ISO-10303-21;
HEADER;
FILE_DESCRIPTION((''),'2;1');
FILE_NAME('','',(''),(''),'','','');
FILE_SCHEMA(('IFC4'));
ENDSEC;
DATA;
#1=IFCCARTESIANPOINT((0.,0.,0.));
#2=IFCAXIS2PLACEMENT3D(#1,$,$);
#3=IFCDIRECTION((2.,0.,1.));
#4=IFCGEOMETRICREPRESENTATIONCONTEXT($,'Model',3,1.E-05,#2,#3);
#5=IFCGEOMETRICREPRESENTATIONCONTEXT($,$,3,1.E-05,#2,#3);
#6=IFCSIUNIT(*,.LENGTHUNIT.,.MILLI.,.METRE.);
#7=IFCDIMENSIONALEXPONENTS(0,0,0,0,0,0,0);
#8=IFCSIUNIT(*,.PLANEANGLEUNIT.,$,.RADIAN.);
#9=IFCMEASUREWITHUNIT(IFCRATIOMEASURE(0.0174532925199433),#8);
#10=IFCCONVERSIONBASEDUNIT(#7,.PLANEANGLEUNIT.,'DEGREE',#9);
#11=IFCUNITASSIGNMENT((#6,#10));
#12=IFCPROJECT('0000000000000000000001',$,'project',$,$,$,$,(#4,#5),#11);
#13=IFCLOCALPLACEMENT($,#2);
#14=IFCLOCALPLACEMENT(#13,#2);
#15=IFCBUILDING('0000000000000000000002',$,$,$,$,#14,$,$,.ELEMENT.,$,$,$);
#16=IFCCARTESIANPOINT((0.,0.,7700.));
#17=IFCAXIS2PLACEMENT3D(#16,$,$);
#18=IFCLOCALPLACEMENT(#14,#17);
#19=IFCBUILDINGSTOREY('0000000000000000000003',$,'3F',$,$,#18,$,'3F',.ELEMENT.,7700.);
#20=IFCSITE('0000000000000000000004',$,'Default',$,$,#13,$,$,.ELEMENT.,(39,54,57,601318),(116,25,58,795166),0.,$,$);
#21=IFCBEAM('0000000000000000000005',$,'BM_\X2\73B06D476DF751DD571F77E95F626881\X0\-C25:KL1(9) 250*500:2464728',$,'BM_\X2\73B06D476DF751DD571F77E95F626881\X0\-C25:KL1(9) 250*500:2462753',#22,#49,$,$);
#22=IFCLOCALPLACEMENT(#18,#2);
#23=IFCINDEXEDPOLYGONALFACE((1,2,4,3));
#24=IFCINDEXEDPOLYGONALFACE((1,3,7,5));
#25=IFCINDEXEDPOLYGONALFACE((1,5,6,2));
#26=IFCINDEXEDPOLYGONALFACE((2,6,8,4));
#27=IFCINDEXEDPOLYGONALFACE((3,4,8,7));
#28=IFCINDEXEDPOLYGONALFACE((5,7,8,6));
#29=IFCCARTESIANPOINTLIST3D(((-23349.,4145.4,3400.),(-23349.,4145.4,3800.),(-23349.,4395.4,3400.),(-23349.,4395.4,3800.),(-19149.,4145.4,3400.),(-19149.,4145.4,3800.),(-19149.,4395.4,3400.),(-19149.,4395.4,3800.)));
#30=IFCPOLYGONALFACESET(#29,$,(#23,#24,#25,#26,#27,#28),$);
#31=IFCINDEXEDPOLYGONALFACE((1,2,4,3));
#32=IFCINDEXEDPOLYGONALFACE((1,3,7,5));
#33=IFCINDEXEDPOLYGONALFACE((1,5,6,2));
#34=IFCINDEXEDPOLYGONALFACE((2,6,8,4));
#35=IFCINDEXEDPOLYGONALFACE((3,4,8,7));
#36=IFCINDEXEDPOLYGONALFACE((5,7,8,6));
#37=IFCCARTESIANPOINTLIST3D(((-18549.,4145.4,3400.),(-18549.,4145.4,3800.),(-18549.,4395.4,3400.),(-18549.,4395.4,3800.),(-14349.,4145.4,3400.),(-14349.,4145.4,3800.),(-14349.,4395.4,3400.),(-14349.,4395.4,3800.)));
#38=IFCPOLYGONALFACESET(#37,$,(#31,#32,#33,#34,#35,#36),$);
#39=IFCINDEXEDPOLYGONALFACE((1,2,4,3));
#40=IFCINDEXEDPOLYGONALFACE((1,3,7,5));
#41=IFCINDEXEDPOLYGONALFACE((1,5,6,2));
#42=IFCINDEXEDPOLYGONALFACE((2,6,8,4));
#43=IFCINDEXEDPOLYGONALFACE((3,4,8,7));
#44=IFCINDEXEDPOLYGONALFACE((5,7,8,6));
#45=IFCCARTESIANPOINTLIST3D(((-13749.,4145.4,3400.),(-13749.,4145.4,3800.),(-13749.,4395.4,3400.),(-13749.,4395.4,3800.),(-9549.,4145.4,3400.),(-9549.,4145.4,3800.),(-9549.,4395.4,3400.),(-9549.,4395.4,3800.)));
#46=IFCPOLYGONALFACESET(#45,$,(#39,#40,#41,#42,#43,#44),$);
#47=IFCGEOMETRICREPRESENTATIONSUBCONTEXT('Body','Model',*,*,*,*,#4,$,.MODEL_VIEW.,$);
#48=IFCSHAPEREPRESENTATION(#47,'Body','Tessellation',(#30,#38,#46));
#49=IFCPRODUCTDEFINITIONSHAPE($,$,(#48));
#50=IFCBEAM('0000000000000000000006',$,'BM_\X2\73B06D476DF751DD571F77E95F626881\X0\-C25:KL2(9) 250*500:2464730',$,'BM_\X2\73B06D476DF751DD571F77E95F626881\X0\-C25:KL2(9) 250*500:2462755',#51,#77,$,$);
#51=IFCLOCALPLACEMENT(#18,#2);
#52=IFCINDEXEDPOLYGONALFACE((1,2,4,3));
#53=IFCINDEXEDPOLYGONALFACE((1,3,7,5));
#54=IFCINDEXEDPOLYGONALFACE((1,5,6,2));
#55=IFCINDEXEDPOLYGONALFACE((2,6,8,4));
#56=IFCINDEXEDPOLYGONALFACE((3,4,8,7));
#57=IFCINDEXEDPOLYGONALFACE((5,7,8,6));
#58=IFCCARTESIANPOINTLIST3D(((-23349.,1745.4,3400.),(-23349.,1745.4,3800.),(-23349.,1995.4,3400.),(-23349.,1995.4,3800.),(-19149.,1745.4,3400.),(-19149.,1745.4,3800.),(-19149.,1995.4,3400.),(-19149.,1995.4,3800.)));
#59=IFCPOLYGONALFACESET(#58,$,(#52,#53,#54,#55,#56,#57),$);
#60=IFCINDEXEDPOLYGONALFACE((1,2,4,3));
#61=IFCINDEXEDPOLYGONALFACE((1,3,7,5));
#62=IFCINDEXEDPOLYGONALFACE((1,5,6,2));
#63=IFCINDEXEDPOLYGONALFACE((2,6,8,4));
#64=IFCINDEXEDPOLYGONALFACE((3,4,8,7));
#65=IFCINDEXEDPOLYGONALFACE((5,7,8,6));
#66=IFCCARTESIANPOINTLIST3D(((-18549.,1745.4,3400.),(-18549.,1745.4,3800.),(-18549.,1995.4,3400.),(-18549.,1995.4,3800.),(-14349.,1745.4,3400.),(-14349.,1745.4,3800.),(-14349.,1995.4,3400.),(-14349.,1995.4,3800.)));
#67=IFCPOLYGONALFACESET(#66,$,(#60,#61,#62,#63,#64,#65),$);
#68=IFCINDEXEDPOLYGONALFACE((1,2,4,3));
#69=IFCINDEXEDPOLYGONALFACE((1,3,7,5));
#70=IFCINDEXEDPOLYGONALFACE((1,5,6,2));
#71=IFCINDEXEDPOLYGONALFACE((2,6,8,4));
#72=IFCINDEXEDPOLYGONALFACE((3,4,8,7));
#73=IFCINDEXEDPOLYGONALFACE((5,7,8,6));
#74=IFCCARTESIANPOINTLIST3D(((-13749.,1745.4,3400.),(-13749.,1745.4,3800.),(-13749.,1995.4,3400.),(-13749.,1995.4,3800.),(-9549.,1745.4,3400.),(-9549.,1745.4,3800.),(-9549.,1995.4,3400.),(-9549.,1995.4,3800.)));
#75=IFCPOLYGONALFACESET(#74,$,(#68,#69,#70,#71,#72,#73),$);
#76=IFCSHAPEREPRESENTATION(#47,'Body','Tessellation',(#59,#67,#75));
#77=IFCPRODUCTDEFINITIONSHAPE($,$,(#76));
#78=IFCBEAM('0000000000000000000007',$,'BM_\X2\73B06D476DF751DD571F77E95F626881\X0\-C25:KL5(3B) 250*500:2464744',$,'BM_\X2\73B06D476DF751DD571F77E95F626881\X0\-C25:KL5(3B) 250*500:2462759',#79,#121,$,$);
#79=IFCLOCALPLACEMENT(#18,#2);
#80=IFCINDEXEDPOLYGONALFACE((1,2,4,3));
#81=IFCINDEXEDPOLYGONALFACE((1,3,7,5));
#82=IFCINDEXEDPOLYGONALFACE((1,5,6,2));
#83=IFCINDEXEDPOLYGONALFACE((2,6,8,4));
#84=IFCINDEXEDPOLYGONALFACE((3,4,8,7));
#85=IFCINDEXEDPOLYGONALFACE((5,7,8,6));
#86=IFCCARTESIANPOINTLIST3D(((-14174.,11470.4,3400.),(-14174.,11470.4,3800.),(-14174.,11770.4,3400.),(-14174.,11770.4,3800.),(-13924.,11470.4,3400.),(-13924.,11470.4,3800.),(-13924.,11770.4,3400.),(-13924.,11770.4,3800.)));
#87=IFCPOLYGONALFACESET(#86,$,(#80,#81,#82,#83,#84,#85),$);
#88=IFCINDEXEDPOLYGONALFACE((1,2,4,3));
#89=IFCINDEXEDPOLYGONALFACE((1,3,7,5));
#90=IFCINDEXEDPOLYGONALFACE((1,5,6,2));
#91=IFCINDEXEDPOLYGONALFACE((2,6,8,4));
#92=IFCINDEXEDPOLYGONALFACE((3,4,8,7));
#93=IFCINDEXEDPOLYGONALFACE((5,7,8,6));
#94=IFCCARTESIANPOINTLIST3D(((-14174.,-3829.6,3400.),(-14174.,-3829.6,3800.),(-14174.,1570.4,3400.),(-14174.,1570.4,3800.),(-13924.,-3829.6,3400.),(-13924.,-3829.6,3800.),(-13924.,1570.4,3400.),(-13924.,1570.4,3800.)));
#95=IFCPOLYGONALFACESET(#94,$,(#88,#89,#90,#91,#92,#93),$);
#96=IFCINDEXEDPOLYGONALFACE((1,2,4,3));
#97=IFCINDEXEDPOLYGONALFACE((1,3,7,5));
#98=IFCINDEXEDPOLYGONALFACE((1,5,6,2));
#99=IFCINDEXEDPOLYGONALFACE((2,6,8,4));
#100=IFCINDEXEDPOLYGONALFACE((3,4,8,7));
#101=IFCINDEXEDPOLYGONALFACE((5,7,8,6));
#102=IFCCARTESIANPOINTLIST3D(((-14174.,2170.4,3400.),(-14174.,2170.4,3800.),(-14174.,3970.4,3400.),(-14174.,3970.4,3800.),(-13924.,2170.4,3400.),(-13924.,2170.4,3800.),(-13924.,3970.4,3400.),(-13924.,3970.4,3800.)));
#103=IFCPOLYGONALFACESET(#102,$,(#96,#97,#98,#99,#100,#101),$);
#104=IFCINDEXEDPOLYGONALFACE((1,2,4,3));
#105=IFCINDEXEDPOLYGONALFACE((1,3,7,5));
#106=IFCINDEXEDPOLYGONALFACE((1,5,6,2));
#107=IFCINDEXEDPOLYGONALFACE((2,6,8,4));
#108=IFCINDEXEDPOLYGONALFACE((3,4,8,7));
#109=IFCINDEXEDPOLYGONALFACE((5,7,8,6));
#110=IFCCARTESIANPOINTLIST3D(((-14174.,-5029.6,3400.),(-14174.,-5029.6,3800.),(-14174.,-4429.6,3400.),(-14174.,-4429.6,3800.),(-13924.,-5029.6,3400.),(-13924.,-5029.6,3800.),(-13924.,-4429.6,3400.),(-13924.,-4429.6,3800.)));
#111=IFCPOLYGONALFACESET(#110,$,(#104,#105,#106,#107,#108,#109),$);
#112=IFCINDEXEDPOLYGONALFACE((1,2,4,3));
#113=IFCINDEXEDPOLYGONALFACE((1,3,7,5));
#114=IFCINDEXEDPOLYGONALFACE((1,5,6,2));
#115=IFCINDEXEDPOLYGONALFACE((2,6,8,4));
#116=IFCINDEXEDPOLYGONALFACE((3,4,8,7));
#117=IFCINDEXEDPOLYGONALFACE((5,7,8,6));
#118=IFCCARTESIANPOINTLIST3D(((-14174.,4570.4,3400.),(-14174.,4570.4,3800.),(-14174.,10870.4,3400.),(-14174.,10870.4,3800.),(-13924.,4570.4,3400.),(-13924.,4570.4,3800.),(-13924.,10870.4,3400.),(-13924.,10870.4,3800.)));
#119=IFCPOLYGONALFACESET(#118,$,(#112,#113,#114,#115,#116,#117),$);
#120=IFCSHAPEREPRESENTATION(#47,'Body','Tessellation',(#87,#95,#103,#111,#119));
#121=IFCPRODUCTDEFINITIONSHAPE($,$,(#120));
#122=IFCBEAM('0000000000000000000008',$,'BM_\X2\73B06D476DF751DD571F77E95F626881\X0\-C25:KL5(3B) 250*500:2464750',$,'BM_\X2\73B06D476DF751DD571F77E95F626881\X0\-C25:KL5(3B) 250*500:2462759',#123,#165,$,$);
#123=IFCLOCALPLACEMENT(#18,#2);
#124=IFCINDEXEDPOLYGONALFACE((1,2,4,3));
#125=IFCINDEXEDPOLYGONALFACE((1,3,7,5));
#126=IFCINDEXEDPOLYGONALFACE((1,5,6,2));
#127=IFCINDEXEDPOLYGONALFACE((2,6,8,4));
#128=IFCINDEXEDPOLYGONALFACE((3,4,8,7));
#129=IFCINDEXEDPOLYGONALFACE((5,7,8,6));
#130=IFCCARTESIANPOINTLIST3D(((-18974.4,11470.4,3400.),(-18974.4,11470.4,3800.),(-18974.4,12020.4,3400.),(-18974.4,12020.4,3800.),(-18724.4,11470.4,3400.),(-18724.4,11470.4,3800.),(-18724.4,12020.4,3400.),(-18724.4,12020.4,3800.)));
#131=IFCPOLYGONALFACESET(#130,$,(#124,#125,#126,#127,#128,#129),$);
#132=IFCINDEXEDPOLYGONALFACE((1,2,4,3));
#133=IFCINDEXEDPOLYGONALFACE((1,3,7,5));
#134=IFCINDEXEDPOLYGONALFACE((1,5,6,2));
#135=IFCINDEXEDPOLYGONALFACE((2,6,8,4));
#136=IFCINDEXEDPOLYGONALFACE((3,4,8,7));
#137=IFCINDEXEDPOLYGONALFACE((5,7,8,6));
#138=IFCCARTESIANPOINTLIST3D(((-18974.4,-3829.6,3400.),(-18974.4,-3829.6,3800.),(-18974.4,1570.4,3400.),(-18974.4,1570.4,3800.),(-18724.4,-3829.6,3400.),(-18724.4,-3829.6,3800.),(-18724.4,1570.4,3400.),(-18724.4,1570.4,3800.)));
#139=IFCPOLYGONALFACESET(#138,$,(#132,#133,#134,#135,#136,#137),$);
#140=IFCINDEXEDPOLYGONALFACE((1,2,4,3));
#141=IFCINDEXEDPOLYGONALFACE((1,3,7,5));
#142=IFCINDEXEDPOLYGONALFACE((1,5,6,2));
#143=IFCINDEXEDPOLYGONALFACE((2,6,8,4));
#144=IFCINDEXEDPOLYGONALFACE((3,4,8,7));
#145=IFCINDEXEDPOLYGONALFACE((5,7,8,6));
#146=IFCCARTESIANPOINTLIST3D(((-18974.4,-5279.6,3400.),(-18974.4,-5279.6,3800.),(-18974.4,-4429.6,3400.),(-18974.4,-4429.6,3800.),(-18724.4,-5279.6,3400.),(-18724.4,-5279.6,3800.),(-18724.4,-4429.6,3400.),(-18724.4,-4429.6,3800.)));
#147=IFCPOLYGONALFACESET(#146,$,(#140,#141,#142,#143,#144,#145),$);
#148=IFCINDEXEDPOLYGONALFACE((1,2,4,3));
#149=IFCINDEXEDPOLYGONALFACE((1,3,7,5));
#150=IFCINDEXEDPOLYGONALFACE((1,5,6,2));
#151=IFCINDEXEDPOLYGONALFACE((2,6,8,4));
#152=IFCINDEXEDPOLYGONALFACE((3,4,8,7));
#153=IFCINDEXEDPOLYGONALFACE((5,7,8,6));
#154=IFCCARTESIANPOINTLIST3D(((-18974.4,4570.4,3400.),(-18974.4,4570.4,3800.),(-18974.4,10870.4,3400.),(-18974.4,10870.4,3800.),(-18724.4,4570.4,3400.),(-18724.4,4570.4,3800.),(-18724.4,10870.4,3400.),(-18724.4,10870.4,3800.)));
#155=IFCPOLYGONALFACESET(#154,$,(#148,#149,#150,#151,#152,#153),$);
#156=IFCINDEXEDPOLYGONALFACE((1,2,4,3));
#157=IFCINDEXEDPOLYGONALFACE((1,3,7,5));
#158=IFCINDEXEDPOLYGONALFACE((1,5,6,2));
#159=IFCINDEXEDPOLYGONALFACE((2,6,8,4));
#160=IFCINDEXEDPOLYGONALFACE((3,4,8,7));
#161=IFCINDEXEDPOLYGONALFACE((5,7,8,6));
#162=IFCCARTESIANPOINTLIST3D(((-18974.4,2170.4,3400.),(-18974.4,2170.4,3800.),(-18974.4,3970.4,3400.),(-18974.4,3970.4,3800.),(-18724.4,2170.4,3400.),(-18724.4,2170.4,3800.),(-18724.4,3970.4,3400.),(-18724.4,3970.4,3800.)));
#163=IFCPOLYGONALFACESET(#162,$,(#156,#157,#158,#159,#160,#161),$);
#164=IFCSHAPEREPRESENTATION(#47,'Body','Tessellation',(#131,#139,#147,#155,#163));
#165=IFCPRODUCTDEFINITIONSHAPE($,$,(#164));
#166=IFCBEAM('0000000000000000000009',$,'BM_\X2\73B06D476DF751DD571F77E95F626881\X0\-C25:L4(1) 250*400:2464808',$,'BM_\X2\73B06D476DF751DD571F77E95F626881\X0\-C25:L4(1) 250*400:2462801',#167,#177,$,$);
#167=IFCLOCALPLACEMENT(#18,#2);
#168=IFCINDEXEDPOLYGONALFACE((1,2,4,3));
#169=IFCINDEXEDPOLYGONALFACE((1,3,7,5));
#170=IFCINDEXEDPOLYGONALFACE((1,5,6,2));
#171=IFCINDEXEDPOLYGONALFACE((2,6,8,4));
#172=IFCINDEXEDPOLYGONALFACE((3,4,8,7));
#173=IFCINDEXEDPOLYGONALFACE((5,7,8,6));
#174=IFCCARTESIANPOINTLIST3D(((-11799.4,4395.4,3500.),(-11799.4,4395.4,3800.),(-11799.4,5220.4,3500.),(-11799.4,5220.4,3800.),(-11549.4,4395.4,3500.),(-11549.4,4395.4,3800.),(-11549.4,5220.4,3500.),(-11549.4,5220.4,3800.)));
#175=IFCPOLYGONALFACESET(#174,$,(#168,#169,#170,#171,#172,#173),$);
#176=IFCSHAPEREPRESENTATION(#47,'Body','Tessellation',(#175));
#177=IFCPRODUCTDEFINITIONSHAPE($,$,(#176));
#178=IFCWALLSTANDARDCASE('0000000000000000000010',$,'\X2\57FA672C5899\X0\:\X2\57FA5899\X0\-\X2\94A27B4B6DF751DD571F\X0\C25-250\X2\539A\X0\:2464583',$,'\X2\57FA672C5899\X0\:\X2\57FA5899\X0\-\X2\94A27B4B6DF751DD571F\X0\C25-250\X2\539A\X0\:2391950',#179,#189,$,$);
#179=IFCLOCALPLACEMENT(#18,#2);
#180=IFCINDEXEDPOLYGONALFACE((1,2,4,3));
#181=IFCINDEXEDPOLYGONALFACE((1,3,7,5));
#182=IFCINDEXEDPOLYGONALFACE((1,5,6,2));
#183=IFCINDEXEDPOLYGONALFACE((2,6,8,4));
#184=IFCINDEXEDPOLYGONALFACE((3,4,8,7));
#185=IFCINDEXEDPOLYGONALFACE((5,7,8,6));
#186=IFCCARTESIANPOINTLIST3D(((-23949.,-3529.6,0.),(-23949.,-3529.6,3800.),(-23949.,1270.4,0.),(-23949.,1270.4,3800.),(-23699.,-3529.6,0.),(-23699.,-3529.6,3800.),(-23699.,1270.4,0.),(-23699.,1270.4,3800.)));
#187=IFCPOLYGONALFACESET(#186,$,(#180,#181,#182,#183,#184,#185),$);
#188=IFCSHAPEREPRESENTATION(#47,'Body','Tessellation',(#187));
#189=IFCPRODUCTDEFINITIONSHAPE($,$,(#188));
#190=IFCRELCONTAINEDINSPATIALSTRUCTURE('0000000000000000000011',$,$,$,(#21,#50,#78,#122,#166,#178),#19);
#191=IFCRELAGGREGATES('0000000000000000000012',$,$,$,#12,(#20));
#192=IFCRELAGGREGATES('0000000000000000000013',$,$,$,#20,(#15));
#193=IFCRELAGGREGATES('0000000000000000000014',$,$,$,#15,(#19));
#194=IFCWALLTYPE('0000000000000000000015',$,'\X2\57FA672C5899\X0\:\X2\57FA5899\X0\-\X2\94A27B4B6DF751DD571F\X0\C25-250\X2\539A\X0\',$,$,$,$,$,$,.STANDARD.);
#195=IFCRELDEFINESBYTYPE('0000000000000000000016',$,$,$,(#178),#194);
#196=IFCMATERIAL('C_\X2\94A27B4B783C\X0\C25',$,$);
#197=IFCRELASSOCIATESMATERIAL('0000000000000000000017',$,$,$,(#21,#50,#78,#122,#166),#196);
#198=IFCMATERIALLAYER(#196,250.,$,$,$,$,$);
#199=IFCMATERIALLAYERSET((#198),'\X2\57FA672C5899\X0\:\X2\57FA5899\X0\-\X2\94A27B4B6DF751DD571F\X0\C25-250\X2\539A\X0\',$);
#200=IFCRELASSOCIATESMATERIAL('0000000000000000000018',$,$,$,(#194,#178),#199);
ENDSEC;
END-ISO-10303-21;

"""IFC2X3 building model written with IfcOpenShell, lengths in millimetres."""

from ifc_helpers import new_model, entity, si_unit, converted_unit, direction, frame, frame_2d, origin, origin_2d_with_axis, place, context, subcontext, project, spatial, polyline, rectangle, extrude, clip, bounded_halfspace, material, layer, layer_set, layer_usage, type_object, element, save


model = new_model("IFC2X3")

# Units and contexts
model_context = context("Model", 3, precision=1e-05, world=origin(), true_north=direction((2.0, 0.0, 1.0)))
context_of_model = context(None, 3, precision=1e-05, world=origin(), true_north=direction((2.0, 0.0, 1.0)))
body_context = subcontext(model_context, "Body", "Model", "MODEL_VIEW")
ifc_project = project(units=[si_unit("LENGTHUNIT", "METRE", prefix="MILLI"), converted_unit("PLANEANGLEUNIT", "DEGREE", entity("IfcRatioMeasure", 0.0174532925199433), si_unit("PLANEANGLEUNIT", "RADIAN"), dimensions=[0, 0, 0, 0, 0, 0, 0])], contexts=[model_context, context_of_model])

# Site, building, storey
site_placement = place(None, origin())
site = spatial("IfcSite", under=ifc_project, at=site_placement, Name="Default", CompositionType="ELEMENT", RefLatitude=(39, 54, 57, 601318), RefLongitude=(116, 25, 58, 795166), RefElevation=0.0)
building_placement = place(site_placement, origin())
building = spatial("IfcBuilding", under=site, at=building_placement, CompositionType="ELEMENT")
storey_placement = place(building_placement, frame((0.0, 0.0, 7700.0)))
storey = spatial("IfcBuildingStorey", under=building, at=storey_placement, Name="3F", LongName="3F", CompositionType="ELEMENT", Elevation=7700.0)

# Beams
ifc_material = material(Name="C_钢筋砼C25")
beam_1_placement = place(storey_placement, frame((-23649.0, 4270.4, 3900.0)))
element("IfcBeam", 1, at=beam_1_placement, inside=storey, material=ifc_material, Name="BM_现浇混凝土矩形梁-C25:KL1(9) 250*500:2464728", ObjectType="BM_现浇混凝土矩形梁-C25:KL1(9) 250*500:2462753", context=body_context, shape_type="SweptSolid", body=[
    extrude(rectangle(XDim=400.0, YDim=250.0, at=frame_2d((0.0, 0.0), x_axis=(1.0, 0.0))), frame((300.0, 0.0, -300.0), z_axis=(1.0, 0.0, 0.0), x_axis=(0.0, 0.0, 1.0)), (0.0, 0.0, 1.0), 4200.0),
    extrude(rectangle(XDim=400.0, YDim=250.0, at=frame_2d((0.0, 0.0), x_axis=(1.0, 0.0))), frame((5100.0, 0.0, -300.0), z_axis=(1.0, 0.0, 0.0), x_axis=(0.0, 0.0, 1.0)), (0.0, 0.0, 1.0), 4200.0),
    extrude(rectangle(XDim=400.0, YDim=250.0, at=frame_2d((0.0, 0.0), x_axis=(1.0, 0.0))), frame((9900.0, 0.0, -300.0), z_axis=(1.0, 0.0, 0.0), x_axis=(0.0, 0.0, 1.0)), (0.0, 0.0, 1.0), 4200.0),
])
beam_2_placement = place(storey_placement, frame((-23649.0, 1870.4, 3900.0)))
element("IfcBeam", 2, at=beam_2_placement, inside=storey, material=ifc_material, Name="BM_现浇混凝土矩形梁-C25:KL2(9) 250*500:2464730", ObjectType="BM_现浇混凝土矩形梁-C25:KL2(9) 250*500:2462755", context=body_context, shape_type="SweptSolid", body=[
    extrude(rectangle(XDim=400.0, YDim=250.0, at=frame_2d((0.0, 0.0), x_axis=(1.0, 0.0))), frame((300.0, 0.0, -300.0), z_axis=(1.0, 0.0, 0.0), x_axis=(0.0, 0.0, 1.0)), (0.0, 0.0, 1.0), 4200.0),
    extrude(rectangle(XDim=400.0, YDim=250.0, at=frame_2d((0.0, 0.0), x_axis=(1.0, 0.0))), frame((5100.0, 0.0, -300.0), z_axis=(1.0, 0.0, 0.0), x_axis=(0.0, 0.0, 1.0)), (0.0, 0.0, 1.0), 4200.0),
    extrude(rectangle(XDim=400.0, YDim=250.0, at=frame_2d((0.0, 0.0), x_axis=(1.0, 0.0))), frame((9900.0, 0.0, -300.0), z_axis=(1.0, 0.0, 0.0), x_axis=(0.0, 0.0, 1.0)), (0.0, 0.0, 1.0), 4200.0),
])
beam_3_placement = place(storey_placement, frame((-14049.0, 11895.4, 3900.0), z_axis=(0.0, 0.0, 1.0), x_axis=(0.0, -1.0, 0.0)))
element("IfcBeam", 3, at=beam_3_placement, inside=storey, material=ifc_material, Name="BM_现浇混凝土矩形梁-C25:KL5(3B) 250*500:2464744", ObjectType="BM_现浇混凝土矩形梁-C25:KL5(3B) 250*500:2462759", context=body_context, shape_type="SweptSolid", body=[
    extrude(rectangle(XDim=400.0, YDim=250.0, at=origin_2d_with_axis()), frame((125.0, 0.0, -300.0), z_axis=(1.0, 0.0, 0.0), x_axis=(0.0, 0.0, 1.0)), (0.0, 0.0, 1.0), 300.0),
    extrude(rectangle(XDim=400.0, YDim=250.0, at=frame_2d((0.0, 0.0), x_axis=(1.0, 0.0))), frame((10325.0, 0.0, -300.0), z_axis=(1.0, 0.0, 0.0), x_axis=(0.0, 0.0, 1.0)), (0.0, 0.0, 1.0), 5400.0),
    extrude(rectangle(XDim=400.0, YDim=250.0, at=origin_2d_with_axis()), frame((7925.0, 0.0, -300.0), z_axis=(1.0, 0.0, 0.0), x_axis=(0.0, 0.0, 1.0)), (0.0, 0.0, 1.0), 1800.0),
    extrude(rectangle(XDim=400.0, YDim=250.0, at=frame_2d((0.0, 0.0), x_axis=(1.0, 0.0))), frame((16325.0, 0.0, -300.0), z_axis=(1.0, 0.0, 0.0), x_axis=(0.0, 0.0, 1.0)), (0.0, 0.0, 1.0), 600.0),
    extrude(rectangle(XDim=400.0, YDim=250.0, at=origin_2d_with_axis()), frame((1025.0, 0.0, -300.0), z_axis=(1.0, 0.0, 0.0), x_axis=(0.0, 0.0, 1.0)), (0.0, 0.0, 1.0), 6300.0),
])
beam_4_placement = place(storey_placement, frame((-18849.4, 11895.4, 3900.0), z_axis=(0.0, 0.0, 1.0), x_axis=(0.0, -1.0, 0.0)))
element("IfcBeam", 4, at=beam_4_placement, inside=storey, material=ifc_material, Name="BM_现浇混凝土矩形梁-C25:KL5(3B) 250*500:2464750", ObjectType="BM_现浇混凝土矩形梁-C25:KL5(3B) 250*500:2462759", context=body_context, shape_type="SweptSolid", body=[
    extrude(rectangle(XDim=400.0, YDim=250.0, at=origin_2d_with_axis()), frame((-125.0, 0.0, -300.0), z_axis=(1.0, 0.0, 0.0), x_axis=(0.0, 0.0, 1.0)), (0.0, 0.0, 1.0), 550.0),
    extrude(rectangle(XDim=400.0, YDim=250.0, at=frame_2d((0.0, 0.0), x_axis=(1.0, 0.0))), frame((10325.0, 0.0, -300.0), z_axis=(1.0, 0.0, 0.0), x_axis=(0.0, 0.0, 1.0)), (0.0, 0.0, 1.0), 5400.0),
    extrude(rectangle(XDim=400.0, YDim=250.0, at=frame_2d((0.0, 0.0), x_axis=(1.0, 0.0))), frame((16325.0, 0.0, -300.0), z_axis=(1.0, 0.0, 0.0), x_axis=(0.0, 0.0, 1.0)), (0.0, 0.0, 1.0), 850.0),
    extrude(rectangle(XDim=400.0, YDim=250.0, at=origin_2d_with_axis()), frame((1025.0, 0.0, -300.0), z_axis=(1.0, 0.0, 0.0), x_axis=(0.0, 0.0, 1.0)), (0.0, 0.0, 1.0), 6300.0),
    extrude(rectangle(XDim=400.0, YDim=250.0, at=origin_2d_with_axis()), frame((7925.0, 0.0, -300.0), z_axis=(1.0, 0.0, 0.0), x_axis=(0.0, 0.0, 1.0)), (0.0, 0.0, 1.0), 1800.0),
])
beam_5_placement = place(storey_placement, frame((-11674.4, 4270.4, 3900.0), z_axis=(0.0, 0.0, 1.0), x_axis=(0.0, 1.0, 0.0)))
element("IfcBeam", 5, at=beam_5_placement, inside=storey, material=ifc_material, Name="BM_现浇混凝土矩形梁-C25:L4(1) 250*400:2464808", ObjectType="BM_现浇混凝土矩形梁-C25:L4(1) 250*400:2462801", context=body_context, shape_type="SweptSolid", body=[
    extrude(rectangle(XDim=300.0, YDim=250.0, at=frame_2d((0.0, 0.0), x_axis=(1.0, 0.0))), frame((125.0, 0.0, -250.0), z_axis=(1.0, 0.0, 0.0), x_axis=(0.0, 0.0, -1.0)), (0.0, 0.0, 1.0), 825.0),
])

# Wall
ifc_layer_1 = layer(ifc_material, 250.0)
ifc_layer_set_1 = layer_set([ifc_layer_1], Name="基本墙:基墙-钢筋混凝土C25-250厚")
ifc_layer_usage_1 = layer_usage(ifc_layer_set_1, "AXIS2", "NEGATIVE", 125.0)
wall_type_1 = type_object("IfcWallType", Name="基本墙:基墙-钢筋混凝土C25-250厚", PredefinedType="STANDARD", material=ifc_layer_set_1)
wall_1_placement = place(storey_placement, frame((-23824.0, -3529.6, 0.0), z_axis=(0.0, 0.0, 1.0), x_axis=(0.0, 1.0, 0.0)))
element("IfcWallStandardCase", 6, at=wall_1_placement, inside=storey, type_object=wall_type_1, material=ifc_layer_usage_1, Name="基本墙:基墙-钢筋混凝土C25-250厚:2464583", ObjectType="基本墙:基墙-钢筋混凝土C25-250厚:2391950", context=body_context, shape_type="Clipping", body=[
    clip(clip(clip(extrude(rectangle(XDim=4800.0, YDim=250.0, at=frame_2d((2400.0, 0.0), x_axis=(-1.0, 0.0))), origin(), (0.0, 0.0, 1.0), 3900.0), bounded_halfspace(frame((4800.0, -125.0, 0.0), z_axis=(-1.0, 0.0, 0.0), x_axis=(0.0, 0.0, -1.0)), True, frame((4800.0, -125.0, 0.0), z_axis=(-1.0, 0.0, 0.0), x_axis=(0.0, 0.0, -1.0)), polyline([(0.0, 0.0), (-3800.0, 0.0), (-3800.0, -250.0), (0.0, -250.0), (0.0, 0.0)]))), bounded_halfspace(frame((0.0, 125.0, 0.0), z_axis=(-1.0, 0.0, 0.0), x_axis=(0.0, 0.0, -1.0)), False, frame((0.0, 125.0, 0.0), z_axis=(-1.0, 0.0, 0.0), x_axis=(0.0, 0.0, -1.0)), polyline([(0.0, 0.0), (0.0, 250.0), (-3800.0, 250.0), (-3800.0, 0.0), (0.0, 0.0)]))), bounded_halfspace(frame((0.0, -125.0, 3800.0), z_axis=(0.0, 0.0, -1.0), x_axis=(1.0, 0.0, 0.0)), True, frame((0.0, -125.0, 3800.0), z_axis=(0.0, 0.0, -1.0), x_axis=(1.0, 0.0, 0.0)), polyline([(0.0, 0.0), (0.0, -250.0), (4800.0, -250.0), (4800.0, 0.0), (0.0, 0.0)]))),
])

save(model, "model.ifc")
